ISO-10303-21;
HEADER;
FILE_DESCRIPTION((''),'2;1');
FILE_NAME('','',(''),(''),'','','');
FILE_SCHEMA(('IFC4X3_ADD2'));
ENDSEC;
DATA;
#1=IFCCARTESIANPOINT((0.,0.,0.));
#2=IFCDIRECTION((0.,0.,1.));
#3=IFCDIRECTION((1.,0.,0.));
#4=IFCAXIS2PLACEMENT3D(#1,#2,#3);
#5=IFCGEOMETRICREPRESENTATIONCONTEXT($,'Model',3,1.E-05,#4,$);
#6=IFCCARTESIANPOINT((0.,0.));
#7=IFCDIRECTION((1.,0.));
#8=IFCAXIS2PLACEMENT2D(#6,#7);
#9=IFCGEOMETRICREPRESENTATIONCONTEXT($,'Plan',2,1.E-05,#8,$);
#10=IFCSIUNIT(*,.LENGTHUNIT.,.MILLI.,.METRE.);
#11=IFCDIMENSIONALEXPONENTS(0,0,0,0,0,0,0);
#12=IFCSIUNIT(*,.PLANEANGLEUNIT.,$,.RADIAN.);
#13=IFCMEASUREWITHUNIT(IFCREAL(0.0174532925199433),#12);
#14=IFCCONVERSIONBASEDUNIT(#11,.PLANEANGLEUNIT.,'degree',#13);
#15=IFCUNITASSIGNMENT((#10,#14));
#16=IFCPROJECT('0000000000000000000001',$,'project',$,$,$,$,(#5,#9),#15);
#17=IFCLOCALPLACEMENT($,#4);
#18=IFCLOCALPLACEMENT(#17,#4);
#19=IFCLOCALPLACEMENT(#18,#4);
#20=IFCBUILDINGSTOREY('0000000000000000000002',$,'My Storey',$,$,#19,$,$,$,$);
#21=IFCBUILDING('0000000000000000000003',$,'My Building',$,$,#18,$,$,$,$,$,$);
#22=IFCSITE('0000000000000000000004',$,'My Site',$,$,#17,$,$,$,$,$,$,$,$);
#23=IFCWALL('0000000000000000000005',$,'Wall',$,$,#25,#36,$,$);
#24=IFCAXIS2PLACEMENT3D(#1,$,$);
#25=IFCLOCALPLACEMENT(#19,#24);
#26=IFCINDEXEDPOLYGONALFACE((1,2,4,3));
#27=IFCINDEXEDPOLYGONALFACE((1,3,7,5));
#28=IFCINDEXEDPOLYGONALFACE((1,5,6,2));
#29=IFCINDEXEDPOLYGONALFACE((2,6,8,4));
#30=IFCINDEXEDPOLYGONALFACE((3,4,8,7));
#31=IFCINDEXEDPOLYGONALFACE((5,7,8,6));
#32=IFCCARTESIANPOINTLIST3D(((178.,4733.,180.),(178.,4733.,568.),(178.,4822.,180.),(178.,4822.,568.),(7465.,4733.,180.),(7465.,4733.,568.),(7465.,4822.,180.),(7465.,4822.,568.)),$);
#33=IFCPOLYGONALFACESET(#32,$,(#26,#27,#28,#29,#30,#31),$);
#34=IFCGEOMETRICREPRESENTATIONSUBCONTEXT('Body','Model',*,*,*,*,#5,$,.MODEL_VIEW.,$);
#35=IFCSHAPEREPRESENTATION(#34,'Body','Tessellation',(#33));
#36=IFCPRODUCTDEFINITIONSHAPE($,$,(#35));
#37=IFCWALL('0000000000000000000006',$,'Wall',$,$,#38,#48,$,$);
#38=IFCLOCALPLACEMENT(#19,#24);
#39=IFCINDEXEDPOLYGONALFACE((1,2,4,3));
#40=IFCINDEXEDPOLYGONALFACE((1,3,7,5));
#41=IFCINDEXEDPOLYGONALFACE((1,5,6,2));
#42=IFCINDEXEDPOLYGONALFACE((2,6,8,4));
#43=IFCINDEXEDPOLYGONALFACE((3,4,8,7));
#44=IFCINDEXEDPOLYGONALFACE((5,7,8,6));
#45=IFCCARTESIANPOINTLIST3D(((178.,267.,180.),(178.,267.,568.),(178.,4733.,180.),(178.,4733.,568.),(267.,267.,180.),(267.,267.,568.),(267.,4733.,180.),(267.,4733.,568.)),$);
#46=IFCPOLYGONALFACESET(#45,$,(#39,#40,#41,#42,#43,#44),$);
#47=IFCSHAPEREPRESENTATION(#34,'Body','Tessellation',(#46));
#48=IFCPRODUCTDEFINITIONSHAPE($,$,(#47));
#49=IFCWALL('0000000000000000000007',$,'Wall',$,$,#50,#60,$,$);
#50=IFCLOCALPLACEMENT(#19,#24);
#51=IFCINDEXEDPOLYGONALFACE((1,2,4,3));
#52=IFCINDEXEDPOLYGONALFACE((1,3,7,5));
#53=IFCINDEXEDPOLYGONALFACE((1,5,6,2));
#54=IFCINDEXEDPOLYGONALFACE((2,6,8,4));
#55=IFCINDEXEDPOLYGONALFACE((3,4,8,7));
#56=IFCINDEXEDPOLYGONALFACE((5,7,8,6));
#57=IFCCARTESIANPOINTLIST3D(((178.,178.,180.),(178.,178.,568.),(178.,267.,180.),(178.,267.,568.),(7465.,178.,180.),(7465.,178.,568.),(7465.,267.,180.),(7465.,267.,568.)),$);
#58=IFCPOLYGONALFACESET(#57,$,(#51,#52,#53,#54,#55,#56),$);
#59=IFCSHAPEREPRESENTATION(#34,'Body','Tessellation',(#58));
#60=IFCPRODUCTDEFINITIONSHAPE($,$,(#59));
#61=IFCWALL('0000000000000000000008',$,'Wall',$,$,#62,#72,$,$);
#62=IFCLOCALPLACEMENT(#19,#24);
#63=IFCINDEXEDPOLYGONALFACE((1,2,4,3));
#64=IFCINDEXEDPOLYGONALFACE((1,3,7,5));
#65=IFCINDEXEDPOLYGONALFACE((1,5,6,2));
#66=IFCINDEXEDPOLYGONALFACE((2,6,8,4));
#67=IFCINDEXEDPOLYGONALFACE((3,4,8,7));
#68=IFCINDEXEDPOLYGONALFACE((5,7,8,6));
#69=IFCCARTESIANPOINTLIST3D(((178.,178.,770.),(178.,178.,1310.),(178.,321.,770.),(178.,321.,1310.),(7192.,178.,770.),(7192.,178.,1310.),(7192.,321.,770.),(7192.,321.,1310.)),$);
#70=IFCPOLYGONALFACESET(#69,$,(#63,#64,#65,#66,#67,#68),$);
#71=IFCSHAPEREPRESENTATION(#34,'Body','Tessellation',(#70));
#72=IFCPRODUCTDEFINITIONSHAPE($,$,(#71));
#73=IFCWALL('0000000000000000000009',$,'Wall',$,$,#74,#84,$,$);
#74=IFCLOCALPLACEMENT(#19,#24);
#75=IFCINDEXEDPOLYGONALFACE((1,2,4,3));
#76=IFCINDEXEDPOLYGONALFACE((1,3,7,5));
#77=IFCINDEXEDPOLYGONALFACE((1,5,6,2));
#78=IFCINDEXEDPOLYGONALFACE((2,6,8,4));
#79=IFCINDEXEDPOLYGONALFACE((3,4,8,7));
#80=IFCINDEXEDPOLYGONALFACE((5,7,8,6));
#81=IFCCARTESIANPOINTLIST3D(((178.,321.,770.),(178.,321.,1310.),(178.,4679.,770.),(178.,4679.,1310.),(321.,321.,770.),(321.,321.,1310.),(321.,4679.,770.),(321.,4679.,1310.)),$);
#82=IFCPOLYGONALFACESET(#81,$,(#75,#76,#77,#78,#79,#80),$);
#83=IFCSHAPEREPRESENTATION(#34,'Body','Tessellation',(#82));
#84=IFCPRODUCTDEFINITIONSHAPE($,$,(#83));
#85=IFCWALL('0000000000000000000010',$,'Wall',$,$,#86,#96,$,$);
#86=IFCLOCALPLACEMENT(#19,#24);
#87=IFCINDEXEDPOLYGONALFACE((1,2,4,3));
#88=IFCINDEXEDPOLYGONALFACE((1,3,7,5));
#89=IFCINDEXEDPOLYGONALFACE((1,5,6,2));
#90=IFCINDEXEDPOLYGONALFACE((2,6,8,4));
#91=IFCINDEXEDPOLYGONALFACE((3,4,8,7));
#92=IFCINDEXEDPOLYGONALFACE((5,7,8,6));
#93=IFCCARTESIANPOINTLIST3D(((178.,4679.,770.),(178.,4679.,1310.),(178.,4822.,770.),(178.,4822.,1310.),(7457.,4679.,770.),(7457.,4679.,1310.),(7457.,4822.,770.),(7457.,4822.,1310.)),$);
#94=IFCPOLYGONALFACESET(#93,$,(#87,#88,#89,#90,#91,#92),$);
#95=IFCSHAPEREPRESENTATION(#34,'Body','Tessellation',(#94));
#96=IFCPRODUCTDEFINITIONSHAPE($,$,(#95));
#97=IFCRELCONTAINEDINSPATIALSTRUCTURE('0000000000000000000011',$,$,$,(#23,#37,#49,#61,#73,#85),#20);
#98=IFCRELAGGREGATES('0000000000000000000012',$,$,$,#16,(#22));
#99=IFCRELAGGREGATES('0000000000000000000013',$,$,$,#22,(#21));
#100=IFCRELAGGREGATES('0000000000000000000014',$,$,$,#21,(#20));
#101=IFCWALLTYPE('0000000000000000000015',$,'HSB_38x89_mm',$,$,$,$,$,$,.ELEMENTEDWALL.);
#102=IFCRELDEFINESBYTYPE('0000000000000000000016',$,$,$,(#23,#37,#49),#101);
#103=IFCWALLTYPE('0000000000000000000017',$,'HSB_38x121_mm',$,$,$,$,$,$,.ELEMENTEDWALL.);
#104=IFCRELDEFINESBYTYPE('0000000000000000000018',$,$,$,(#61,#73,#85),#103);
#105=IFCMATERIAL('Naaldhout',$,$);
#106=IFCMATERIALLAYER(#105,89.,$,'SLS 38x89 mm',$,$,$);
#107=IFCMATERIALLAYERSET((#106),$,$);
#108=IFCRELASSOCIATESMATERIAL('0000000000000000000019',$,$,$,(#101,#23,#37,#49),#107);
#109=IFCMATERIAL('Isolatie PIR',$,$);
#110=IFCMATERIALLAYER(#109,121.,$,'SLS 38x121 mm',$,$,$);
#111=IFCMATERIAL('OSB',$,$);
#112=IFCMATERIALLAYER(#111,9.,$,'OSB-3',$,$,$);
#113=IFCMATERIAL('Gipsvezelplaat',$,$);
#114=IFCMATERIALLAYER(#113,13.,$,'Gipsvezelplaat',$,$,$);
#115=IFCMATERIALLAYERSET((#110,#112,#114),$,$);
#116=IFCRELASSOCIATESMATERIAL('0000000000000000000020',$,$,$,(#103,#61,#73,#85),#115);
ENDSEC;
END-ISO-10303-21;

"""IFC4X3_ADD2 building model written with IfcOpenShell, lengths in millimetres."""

from ifc_helpers import new_model, entity, si_unit, converted_unit, frame, origin_with_axes, origin_2d_with_axis, place, context, subcontext, project, spatial, indexed_curve, outline, extrude, material, layer, layer_set, layer_usage, type_object, element, save


model = new_model("IFC4X3_ADD2")

# Units and contexts
model_context = context("Model", 3, precision=1e-05, world=origin_with_axes())
plan_context = context("Plan", 2, precision=1e-05, world=origin_2d_with_axis())
body_context_1 = subcontext(model_context, "Body", "Model", "MODEL_VIEW")
ifc_project = project(units=[si_unit("LENGTHUNIT", "METRE", prefix="MILLI"), converted_unit("PLANEANGLEUNIT", "degree", entity("IfcReal", 0.0174532925199433), si_unit("PLANEANGLEUNIT", "RADIAN"), dimensions=[0, 0, 0, 0, 0, 0, 0])], contexts=[model_context, plan_context])

# Site, building, storey
site_placement = place(None, origin_with_axes())
site = spatial("IfcSite", under=ifc_project, at=site_placement, Name="My Site")
building_placement = place(site_placement, origin_with_axes())
building = spatial("IfcBuilding", under=site, at=building_placement, Name="My Building")
storey_placement = place(building_placement, origin_with_axes())
storey = spatial("IfcBuildingStorey", under=building, at=storey_placement, Name="My Storey")

# Walls
ifc_material_1 = material(Name="Naaldhout")
ifc_layer_1 = layer(ifc_material_1, 89.0, Name="SLS 38x89 mm")
ifc_layer_set_1 = layer_set([ifc_layer_1])
ifc_layer_usage_1 = layer_usage(ifc_layer_set_1, "AXIS2", "POSITIVE", 0.0)
wall_type_1 = type_object("IfcWallType", Name="HSB_38x89_mm", PredefinedType="ELEMENTEDWALL", material=ifc_layer_set_1)
wall_1_placement = place(storey_placement, frame((178.0, 4733.0, 180.0), z_axis=(0.0, 0.0, 1.0), x_axis=(1.0, 0.0, 0.0)))
element("IfcWall", 1, at=wall_1_placement, inside=storey, type_object=wall_type_1, material=ifc_layer_usage_1, Name="Wall", context=body_context_1, shape_type="SweptSolid", body=[
    extrude(outline(indexed_curve([(0.0, 0.0), (0.0, 89.0), (7287.0, 89.0), (7287.0, 0.0), (0.0, 0.0)], self_intersect=False)), origin_with_axes(), (0.0, 0.0, 1.0), 388.0),
])
ifc_layer_usage_2 = layer_usage(ifc_layer_set_1, "AXIS2", "POSITIVE", 0.0)
wall_2_placement = place(storey_placement, frame((178.0, 4733.0, 180.0), z_axis=(0.0, 0.0, 1.0), x_axis=(0.0, -1.0, 0.0)))
element("IfcWall", 2, at=wall_2_placement, inside=storey, type_object=wall_type_1, material=ifc_layer_usage_2, Name="Wall", context=body_context_1, shape_type="SweptSolid", body=[
    extrude(outline(indexed_curve([(0.0, 0.0), (0.0, 89.0), (4466.0, 89.0), (4466.0, 0.0), (0.0, 0.0)], self_intersect=False)), origin_with_axes(), (0.0, 0.0, 1.0), 388.0),
])
ifc_layer_usage_3 = layer_usage(ifc_layer_set_1, "AXIS2", "POSITIVE", 0.0)
wall_3_placement = place(storey_placement, frame((178.0, 178.0, 180.0), z_axis=(0.0, 0.0, 1.0), x_axis=(1.0, 0.0, 0.0)))
element("IfcWall", 3, at=wall_3_placement, inside=storey, type_object=wall_type_1, material=ifc_layer_usage_3, Name="Wall", context=body_context_1, shape_type="SweptSolid", body=[
    extrude(outline(indexed_curve([(0.0, 0.0), (0.0, 89.0), (7287.0, 89.0), (7287.0, 0.0), (0.0, 0.0)], self_intersect=False)), origin_with_axes(), (0.0, 0.0, 1.0), 388.0),
])
ifc_material_2 = material(Name="Isolatie PIR")
ifc_layer_2 = layer(ifc_material_2, 121.0, Name="SLS 38x121 mm")
ifc_material_3 = material(Name="OSB")
ifc_layer_3 = layer(ifc_material_3, 9.0, Name="OSB-3")
ifc_material_4 = material(Name="Gipsvezelplaat")
ifc_layer_4 = layer(ifc_material_4, 13.0, Name="Gipsvezelplaat")
ifc_layer_set_2 = layer_set([ifc_layer_2, ifc_layer_3, ifc_layer_4])
ifc_layer_usage_4 = layer_usage(ifc_layer_set_2, "AXIS2", "POSITIVE", 0.0)
wall_type_2 = type_object("IfcWallType", Name="HSB_38x121_mm", PredefinedType="ELEMENTEDWALL", material=ifc_layer_set_2)
wall_4_placement = place(storey_placement, frame((178.0, 178.0, 770.0), z_axis=(0.0, 0.0, 1.0), x_axis=(1.0, 0.0, 0.0)))
element("IfcWall", 4, at=wall_4_placement, inside=storey, type_object=wall_type_2, material=ifc_layer_usage_4, Name="Wall", context=body_context_1, shape_type="SweptSolid", body=[
    extrude(outline(indexed_curve([(0.0, 0.0), (0.0, 143.0), (7014.0, 143.0), (7014.0, 0.0), (0.0, 0.0)], self_intersect=False)), origin_with_axes(), (0.0, 0.0, 1.0), 540.0),
])
ifc_layer_usage_5 = layer_usage(ifc_layer_set_2, "AXIS2", "POSITIVE", 0.0)
wall_5_placement = place(storey_placement, frame((178.0, 4679.0, 770.0), z_axis=(0.0, 0.0, 1.0), x_axis=(0.0, -1.0, 0.0)))
element("IfcWall", 5, at=wall_5_placement, inside=storey, type_object=wall_type_2, material=ifc_layer_usage_5, Name="Wall", context=body_context_1, shape_type="SweptSolid", body=[
    extrude(outline(indexed_curve([(0.0, 0.0), (0.0, 143.0), (4358.0, 143.0), (4358.0, 0.0), (0.0, 0.0)], self_intersect=False)), origin_with_axes(), (0.0, 0.0, 1.0), 540.0),
])
ifc_layer_usage_6 = layer_usage(ifc_layer_set_2, "AXIS2", "POSITIVE", 0.0)
wall_6_placement = place(storey_placement, frame((178.0, 4679.0, 770.0), z_axis=(0.0, 0.0, 1.0), x_axis=(1.0, 0.0, 0.0)))
element("IfcWall", 6, at=wall_6_placement, inside=storey, type_object=wall_type_2, material=ifc_layer_usage_6, Name="Wall", context=body_context_1, shape_type="SweptSolid", body=[
    extrude(outline(indexed_curve([(0.0, 0.0), (0.0, 143.0), (7279.0, 143.0), (7279.0, 0.0), (0.0, 0.0)], self_intersect=False)), origin_with_axes(), (0.0, 0.0, 1.0), 540.0),
])

save(model, "model.ifc")
